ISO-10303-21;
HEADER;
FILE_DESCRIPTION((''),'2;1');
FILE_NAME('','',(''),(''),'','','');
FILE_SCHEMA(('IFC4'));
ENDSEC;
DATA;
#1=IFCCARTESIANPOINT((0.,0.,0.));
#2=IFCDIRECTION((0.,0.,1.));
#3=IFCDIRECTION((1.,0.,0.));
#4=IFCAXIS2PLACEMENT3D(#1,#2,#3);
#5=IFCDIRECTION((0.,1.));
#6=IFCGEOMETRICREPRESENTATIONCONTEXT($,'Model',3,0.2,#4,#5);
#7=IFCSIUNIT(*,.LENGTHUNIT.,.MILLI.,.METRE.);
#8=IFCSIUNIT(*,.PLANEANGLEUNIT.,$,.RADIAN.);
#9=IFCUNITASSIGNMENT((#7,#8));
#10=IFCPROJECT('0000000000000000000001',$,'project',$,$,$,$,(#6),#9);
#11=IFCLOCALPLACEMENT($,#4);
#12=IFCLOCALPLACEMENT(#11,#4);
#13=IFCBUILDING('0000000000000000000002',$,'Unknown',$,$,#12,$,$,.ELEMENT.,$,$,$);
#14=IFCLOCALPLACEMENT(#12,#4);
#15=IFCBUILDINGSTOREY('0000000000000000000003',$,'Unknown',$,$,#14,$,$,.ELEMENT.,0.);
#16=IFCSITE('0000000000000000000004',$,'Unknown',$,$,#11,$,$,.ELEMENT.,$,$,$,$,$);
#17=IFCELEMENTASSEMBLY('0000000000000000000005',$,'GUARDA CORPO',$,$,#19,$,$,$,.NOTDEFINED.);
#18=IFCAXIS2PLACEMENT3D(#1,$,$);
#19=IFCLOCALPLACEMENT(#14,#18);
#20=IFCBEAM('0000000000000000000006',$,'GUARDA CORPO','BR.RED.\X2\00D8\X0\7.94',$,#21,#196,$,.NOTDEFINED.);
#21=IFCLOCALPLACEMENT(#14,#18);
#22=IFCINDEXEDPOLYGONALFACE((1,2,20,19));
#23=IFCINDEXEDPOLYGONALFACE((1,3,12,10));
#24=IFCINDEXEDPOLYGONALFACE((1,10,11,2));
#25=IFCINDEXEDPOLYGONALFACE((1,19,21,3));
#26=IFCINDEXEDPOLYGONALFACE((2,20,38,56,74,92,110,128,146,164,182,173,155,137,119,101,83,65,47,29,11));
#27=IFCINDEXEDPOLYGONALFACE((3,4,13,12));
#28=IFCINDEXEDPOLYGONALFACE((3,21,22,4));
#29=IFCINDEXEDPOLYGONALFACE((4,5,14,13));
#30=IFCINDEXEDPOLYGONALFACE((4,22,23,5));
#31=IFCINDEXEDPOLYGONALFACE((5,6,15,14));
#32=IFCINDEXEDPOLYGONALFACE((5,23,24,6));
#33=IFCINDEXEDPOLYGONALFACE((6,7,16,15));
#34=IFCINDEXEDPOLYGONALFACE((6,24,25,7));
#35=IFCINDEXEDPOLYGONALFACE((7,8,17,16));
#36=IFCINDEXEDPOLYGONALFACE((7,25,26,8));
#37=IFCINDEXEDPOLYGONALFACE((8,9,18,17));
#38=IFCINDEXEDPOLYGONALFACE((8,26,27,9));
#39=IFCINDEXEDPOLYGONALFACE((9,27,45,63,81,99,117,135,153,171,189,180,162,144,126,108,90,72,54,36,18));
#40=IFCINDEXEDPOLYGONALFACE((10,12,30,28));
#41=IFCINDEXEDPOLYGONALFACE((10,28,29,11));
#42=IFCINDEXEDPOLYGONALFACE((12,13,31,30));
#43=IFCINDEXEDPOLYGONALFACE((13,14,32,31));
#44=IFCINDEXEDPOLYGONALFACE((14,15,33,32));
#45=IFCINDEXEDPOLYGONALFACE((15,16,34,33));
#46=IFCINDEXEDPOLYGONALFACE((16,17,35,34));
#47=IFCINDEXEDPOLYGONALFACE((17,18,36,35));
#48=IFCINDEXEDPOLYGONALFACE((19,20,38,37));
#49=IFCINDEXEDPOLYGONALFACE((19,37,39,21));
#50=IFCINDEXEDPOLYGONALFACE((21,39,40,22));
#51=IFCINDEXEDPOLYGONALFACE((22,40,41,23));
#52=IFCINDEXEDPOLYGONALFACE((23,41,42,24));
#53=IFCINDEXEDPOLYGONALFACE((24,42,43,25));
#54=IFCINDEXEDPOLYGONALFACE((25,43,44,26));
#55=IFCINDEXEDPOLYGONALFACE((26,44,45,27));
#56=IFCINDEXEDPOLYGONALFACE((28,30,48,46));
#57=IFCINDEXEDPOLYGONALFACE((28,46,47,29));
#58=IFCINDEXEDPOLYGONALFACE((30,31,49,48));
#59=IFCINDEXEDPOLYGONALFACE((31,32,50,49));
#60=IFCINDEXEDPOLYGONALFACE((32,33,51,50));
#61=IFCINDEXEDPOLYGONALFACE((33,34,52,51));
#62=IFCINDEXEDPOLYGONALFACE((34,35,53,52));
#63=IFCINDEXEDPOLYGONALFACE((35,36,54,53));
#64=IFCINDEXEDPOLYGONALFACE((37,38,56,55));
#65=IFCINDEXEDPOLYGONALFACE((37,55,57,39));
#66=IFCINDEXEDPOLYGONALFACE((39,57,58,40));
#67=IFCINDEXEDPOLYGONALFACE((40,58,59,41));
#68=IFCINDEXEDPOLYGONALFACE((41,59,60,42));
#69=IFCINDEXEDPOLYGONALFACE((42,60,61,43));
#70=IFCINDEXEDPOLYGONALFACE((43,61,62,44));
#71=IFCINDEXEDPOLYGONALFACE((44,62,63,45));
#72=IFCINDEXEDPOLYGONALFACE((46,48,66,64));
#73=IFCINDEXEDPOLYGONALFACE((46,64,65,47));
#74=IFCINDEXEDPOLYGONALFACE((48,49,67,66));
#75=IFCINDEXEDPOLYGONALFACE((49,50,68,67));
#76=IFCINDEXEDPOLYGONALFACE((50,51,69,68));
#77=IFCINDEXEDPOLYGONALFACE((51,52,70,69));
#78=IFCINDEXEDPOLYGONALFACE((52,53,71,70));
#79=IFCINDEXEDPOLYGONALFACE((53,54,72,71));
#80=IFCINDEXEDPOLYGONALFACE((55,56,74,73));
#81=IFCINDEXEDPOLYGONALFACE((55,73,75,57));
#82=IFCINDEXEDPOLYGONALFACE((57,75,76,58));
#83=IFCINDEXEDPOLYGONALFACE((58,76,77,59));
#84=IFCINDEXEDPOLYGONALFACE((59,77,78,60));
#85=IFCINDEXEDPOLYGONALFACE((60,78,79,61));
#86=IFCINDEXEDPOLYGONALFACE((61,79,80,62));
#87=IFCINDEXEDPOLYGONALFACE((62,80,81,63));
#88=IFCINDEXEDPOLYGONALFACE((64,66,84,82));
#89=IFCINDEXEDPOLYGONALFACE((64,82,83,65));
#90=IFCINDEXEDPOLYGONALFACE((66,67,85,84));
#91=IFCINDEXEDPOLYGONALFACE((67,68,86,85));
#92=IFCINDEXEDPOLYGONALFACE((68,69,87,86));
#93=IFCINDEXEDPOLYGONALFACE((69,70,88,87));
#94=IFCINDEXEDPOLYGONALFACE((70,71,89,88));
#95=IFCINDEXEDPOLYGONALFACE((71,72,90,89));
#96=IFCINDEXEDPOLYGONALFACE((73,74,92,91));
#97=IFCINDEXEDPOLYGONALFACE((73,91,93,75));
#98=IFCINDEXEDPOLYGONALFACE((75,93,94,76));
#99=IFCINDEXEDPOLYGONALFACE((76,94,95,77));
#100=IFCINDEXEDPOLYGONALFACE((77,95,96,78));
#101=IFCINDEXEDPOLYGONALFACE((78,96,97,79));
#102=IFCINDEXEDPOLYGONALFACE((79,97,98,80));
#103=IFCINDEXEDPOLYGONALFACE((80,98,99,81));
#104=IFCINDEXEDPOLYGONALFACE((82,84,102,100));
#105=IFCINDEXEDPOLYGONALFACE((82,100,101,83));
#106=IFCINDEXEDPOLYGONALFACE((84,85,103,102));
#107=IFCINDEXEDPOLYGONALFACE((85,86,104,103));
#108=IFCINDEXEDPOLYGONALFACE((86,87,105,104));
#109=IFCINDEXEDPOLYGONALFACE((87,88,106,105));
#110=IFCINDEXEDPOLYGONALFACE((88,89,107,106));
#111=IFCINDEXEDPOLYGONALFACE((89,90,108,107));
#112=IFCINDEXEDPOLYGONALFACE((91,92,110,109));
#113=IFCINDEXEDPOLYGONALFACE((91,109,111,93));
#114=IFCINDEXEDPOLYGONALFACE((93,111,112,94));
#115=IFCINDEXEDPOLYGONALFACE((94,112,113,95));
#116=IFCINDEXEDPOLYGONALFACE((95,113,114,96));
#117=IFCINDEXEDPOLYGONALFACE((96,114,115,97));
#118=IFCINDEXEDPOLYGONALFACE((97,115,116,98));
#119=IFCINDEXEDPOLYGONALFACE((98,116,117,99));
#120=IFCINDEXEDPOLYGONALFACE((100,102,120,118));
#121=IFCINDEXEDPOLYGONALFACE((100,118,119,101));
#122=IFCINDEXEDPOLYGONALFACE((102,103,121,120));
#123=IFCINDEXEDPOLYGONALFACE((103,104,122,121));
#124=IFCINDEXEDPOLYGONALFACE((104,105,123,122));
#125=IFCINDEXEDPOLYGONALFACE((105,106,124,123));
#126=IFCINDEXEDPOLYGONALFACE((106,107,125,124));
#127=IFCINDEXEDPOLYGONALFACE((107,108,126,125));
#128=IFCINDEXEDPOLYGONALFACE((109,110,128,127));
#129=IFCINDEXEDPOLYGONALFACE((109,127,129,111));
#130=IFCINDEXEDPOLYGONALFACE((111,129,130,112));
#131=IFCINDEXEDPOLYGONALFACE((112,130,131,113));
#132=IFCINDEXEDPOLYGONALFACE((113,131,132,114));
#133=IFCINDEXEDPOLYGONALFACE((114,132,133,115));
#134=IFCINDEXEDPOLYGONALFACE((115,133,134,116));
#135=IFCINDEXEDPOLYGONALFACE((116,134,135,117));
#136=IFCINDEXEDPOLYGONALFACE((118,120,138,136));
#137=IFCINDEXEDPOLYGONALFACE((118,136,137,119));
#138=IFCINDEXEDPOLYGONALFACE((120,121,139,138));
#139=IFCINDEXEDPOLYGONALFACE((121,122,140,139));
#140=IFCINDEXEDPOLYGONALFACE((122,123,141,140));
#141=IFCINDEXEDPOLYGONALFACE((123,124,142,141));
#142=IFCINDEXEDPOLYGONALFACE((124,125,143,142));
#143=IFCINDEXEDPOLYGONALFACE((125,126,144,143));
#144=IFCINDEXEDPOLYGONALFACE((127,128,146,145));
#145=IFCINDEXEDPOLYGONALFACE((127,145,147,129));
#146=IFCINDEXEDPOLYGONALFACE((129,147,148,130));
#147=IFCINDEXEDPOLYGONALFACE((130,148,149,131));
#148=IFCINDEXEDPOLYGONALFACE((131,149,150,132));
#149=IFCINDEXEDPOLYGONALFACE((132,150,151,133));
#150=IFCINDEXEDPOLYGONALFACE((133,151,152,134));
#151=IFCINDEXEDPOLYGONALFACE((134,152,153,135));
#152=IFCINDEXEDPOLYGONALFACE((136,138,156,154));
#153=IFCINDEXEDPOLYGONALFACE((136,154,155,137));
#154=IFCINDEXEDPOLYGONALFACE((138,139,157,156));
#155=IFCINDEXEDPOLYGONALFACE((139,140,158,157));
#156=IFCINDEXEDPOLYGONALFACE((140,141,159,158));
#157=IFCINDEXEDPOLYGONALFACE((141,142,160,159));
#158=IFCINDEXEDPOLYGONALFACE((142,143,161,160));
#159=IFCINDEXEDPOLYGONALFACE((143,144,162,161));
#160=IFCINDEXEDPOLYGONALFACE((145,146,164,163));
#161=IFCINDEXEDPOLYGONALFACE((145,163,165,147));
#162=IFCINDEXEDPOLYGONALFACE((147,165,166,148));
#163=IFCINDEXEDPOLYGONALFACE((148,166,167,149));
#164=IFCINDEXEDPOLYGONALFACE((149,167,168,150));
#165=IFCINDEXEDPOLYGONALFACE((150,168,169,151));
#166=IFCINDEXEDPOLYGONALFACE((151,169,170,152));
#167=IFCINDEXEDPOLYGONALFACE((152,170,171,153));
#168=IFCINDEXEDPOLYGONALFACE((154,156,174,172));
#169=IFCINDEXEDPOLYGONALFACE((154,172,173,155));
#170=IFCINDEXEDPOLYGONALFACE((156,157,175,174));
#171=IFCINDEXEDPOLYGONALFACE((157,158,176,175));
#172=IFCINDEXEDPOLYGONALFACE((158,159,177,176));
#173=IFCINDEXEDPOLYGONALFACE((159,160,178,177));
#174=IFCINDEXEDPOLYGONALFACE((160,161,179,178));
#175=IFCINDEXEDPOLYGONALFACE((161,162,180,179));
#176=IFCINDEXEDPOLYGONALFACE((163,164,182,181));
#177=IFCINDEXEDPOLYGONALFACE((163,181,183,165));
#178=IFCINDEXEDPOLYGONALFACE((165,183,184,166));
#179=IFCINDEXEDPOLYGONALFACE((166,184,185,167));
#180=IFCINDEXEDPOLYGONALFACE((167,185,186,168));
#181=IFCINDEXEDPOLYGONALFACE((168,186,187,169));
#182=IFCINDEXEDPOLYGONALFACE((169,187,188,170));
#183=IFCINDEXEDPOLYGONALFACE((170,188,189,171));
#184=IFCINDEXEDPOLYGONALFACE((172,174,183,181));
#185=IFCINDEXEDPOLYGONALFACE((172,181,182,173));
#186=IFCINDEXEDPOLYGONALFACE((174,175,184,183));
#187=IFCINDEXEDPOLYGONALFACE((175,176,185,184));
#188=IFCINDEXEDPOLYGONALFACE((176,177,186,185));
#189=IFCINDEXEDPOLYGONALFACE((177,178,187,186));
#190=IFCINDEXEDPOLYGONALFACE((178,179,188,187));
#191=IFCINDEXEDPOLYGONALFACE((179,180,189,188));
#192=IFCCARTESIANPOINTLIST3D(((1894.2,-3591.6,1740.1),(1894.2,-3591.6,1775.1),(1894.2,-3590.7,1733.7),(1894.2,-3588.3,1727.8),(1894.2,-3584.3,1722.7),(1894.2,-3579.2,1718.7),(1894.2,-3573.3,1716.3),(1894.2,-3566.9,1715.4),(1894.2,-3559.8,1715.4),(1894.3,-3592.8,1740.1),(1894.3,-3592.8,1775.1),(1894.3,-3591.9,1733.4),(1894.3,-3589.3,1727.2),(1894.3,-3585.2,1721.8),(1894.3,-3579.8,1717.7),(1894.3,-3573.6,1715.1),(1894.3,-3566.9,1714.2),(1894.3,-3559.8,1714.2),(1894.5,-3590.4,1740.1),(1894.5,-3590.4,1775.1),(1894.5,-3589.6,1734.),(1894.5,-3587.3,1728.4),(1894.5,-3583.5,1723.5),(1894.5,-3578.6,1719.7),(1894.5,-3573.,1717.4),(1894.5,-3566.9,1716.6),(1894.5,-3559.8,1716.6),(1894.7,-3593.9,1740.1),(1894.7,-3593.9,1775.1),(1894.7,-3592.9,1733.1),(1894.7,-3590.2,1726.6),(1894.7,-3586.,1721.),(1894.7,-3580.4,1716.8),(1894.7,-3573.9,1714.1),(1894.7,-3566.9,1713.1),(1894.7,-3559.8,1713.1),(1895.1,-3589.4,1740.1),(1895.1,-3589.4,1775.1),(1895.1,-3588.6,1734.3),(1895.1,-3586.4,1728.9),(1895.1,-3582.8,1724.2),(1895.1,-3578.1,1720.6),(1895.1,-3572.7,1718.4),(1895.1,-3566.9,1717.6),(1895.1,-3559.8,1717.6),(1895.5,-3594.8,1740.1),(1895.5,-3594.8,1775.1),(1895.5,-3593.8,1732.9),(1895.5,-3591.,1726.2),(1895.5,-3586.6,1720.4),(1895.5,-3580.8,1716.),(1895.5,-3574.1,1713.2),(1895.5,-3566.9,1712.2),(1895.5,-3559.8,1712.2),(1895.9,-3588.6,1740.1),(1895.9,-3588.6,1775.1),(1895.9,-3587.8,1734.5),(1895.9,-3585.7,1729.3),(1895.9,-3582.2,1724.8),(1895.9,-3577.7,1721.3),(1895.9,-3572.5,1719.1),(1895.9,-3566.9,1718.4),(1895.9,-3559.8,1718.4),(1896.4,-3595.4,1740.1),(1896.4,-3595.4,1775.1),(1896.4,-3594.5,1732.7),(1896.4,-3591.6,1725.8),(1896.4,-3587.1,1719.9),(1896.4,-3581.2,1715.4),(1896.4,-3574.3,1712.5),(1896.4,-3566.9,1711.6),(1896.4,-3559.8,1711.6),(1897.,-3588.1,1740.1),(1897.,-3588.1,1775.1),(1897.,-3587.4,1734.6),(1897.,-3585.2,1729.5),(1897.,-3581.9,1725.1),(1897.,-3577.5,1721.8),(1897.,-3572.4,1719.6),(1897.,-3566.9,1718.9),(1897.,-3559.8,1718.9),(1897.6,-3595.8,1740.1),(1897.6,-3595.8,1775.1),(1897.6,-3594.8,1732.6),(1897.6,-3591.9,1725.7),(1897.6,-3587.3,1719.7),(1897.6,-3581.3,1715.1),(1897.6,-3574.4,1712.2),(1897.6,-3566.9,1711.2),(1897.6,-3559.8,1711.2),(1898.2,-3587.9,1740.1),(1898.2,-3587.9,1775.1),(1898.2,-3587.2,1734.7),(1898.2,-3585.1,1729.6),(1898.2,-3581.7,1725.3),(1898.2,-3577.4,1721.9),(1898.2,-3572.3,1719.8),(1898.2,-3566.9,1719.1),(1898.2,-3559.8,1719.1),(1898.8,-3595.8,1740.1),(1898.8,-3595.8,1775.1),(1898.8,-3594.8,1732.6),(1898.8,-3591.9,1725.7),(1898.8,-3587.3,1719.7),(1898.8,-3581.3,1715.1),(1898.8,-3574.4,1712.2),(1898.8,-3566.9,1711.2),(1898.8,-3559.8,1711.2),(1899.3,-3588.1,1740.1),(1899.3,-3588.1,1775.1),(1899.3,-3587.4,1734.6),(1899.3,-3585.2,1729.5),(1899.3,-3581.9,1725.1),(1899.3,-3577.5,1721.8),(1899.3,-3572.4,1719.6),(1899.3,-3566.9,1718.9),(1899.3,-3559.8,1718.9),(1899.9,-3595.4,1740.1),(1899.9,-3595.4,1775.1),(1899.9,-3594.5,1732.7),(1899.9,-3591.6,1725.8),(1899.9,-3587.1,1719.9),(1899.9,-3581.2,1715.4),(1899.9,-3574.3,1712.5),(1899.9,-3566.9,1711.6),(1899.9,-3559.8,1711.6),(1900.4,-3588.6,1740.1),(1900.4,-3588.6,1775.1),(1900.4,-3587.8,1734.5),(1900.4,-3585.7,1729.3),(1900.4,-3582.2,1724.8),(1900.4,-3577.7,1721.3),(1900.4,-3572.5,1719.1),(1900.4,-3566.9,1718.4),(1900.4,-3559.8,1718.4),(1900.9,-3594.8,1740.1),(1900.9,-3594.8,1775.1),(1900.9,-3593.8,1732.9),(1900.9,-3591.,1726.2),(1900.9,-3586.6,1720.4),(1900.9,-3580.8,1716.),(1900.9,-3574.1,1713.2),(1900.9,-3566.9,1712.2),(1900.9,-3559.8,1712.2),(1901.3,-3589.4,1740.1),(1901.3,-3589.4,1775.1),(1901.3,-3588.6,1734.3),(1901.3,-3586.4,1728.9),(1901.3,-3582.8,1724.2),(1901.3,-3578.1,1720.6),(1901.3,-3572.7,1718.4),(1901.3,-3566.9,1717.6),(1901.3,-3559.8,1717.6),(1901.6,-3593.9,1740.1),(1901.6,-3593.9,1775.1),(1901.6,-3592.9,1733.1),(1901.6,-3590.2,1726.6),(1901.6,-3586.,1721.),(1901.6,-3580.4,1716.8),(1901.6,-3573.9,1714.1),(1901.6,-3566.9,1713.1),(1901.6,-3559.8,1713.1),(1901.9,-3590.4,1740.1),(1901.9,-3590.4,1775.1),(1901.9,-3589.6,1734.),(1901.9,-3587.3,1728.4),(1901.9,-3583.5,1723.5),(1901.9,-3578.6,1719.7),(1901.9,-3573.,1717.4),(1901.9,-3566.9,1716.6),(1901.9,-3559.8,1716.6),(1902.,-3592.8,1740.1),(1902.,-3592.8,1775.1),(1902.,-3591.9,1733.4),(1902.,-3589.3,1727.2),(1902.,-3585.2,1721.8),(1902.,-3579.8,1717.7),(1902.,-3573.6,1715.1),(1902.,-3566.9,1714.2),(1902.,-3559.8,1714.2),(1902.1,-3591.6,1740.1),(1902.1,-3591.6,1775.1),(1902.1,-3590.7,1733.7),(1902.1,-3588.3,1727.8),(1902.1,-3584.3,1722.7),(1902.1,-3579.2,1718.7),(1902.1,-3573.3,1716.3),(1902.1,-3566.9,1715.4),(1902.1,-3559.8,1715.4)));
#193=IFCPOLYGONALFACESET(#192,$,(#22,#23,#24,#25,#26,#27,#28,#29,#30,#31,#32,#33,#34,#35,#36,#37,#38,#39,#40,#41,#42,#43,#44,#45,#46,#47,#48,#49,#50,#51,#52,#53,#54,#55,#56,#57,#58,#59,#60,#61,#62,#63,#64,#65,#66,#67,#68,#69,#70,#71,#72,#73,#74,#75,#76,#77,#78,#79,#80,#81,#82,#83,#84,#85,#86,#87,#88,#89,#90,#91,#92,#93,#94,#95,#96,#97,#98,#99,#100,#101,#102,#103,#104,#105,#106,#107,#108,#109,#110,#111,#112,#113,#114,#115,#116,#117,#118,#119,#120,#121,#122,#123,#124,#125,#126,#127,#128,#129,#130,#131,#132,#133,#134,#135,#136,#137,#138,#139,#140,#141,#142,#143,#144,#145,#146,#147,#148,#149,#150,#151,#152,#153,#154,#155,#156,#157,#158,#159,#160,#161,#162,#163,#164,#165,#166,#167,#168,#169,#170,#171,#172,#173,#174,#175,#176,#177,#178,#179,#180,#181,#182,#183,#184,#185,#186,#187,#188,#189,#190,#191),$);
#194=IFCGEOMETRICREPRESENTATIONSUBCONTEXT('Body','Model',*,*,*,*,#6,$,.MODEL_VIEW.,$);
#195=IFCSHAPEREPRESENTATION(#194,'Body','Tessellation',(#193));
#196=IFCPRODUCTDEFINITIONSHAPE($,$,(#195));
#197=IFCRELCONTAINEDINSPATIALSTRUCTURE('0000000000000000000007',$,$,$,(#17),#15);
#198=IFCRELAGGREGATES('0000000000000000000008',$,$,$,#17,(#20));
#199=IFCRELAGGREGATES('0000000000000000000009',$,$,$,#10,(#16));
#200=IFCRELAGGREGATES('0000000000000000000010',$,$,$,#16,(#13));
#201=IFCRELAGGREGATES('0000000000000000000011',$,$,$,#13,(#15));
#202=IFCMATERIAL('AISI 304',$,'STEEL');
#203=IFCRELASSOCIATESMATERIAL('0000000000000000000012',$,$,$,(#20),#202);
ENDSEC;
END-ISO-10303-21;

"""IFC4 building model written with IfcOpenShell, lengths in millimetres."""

from ifc_helpers import new_model, entity, si_unit, direction, frame, origin_with_axes, place, context, subcontext, project, spatial, material, element, aggregate, save


model = new_model("IFC4")

# Units and contexts
model_context = context("Model", 3, precision=0.2, world=origin_with_axes(), true_north=direction((0.0, 1.0)))
body_context = subcontext(model_context, "Body", "Model", "MODEL_VIEW")
ifc_project = project(units=[si_unit("LENGTHUNIT", "METRE", prefix="MILLI"), si_unit("PLANEANGLEUNIT", "RADIAN")], contexts=[model_context])

# Site, building, storey
site_placement = place(None, origin_with_axes())
site = spatial("IfcSite", under=ifc_project, at=site_placement, Name="Unknown", CompositionType="ELEMENT")
building_placement = place(site_placement, origin_with_axes())
building = spatial("IfcBuilding", under=site, at=building_placement, Name="Unknown", CompositionType="ELEMENT")
storey_placement = place(building_placement, origin_with_axes())
storey = spatial("IfcBuildingStorey", under=building, at=storey_placement, Name="Unknown", CompositionType="ELEMENT", Elevation=0.0)

# Shared definitions
ifc_material_1 = material(Name="AISI 304", Category="STEEL")

# Element assembly, beam
assembly_1_placement = place(storey_placement, frame((833.2, -3540.7, 1615.0), z_axis=(-0.000512, -1.0, -0.000003), x_axis=(0.000003, -0.000003, 1.0)))
assembly_1 = element("IfcElementAssembly", 1, at=assembly_1_placement, inside=storey, Name="GUARDA CORPO", PredefinedType="NOTDEFINED")
beam_1_placement = place(assembly_1_placement, frame((160.1, -1065.0, 50.6), z_axis=(-0.000003, 0.000513, -1.0), x_axis=(-1.0, 0.0, 0.000003)))
beam_1 = element("IfcBeam", 2, at=beam_1_placement, material=ifc_material_1, Name="GUARDA CORPO", Description="BR.RED.Ø7.94", PredefinedType="NOTDEFINED", context=body_context, shape_type="SolidModel", body=[
    entity("IfcSweptDiskSolid", entity("IfcIndexedPolyCurve", entity("IfcCartesianPointList3D", [[0.0, 0.0, 0.0], [35.0, 0.0, 0.0], [52.7, 0.0, 7.3], [60.0, 0.0, 25.0], [60.0, 0.0, 32.1]]), [entity("IfcLineIndex", [1, 2]), entity("IfcArcIndex", [2, 3, 4]), entity("IfcLineIndex", [4, 5])]), 4.0),
])

aggregate(assembly_1, [beam_1])

save(model, "model.ifc")
